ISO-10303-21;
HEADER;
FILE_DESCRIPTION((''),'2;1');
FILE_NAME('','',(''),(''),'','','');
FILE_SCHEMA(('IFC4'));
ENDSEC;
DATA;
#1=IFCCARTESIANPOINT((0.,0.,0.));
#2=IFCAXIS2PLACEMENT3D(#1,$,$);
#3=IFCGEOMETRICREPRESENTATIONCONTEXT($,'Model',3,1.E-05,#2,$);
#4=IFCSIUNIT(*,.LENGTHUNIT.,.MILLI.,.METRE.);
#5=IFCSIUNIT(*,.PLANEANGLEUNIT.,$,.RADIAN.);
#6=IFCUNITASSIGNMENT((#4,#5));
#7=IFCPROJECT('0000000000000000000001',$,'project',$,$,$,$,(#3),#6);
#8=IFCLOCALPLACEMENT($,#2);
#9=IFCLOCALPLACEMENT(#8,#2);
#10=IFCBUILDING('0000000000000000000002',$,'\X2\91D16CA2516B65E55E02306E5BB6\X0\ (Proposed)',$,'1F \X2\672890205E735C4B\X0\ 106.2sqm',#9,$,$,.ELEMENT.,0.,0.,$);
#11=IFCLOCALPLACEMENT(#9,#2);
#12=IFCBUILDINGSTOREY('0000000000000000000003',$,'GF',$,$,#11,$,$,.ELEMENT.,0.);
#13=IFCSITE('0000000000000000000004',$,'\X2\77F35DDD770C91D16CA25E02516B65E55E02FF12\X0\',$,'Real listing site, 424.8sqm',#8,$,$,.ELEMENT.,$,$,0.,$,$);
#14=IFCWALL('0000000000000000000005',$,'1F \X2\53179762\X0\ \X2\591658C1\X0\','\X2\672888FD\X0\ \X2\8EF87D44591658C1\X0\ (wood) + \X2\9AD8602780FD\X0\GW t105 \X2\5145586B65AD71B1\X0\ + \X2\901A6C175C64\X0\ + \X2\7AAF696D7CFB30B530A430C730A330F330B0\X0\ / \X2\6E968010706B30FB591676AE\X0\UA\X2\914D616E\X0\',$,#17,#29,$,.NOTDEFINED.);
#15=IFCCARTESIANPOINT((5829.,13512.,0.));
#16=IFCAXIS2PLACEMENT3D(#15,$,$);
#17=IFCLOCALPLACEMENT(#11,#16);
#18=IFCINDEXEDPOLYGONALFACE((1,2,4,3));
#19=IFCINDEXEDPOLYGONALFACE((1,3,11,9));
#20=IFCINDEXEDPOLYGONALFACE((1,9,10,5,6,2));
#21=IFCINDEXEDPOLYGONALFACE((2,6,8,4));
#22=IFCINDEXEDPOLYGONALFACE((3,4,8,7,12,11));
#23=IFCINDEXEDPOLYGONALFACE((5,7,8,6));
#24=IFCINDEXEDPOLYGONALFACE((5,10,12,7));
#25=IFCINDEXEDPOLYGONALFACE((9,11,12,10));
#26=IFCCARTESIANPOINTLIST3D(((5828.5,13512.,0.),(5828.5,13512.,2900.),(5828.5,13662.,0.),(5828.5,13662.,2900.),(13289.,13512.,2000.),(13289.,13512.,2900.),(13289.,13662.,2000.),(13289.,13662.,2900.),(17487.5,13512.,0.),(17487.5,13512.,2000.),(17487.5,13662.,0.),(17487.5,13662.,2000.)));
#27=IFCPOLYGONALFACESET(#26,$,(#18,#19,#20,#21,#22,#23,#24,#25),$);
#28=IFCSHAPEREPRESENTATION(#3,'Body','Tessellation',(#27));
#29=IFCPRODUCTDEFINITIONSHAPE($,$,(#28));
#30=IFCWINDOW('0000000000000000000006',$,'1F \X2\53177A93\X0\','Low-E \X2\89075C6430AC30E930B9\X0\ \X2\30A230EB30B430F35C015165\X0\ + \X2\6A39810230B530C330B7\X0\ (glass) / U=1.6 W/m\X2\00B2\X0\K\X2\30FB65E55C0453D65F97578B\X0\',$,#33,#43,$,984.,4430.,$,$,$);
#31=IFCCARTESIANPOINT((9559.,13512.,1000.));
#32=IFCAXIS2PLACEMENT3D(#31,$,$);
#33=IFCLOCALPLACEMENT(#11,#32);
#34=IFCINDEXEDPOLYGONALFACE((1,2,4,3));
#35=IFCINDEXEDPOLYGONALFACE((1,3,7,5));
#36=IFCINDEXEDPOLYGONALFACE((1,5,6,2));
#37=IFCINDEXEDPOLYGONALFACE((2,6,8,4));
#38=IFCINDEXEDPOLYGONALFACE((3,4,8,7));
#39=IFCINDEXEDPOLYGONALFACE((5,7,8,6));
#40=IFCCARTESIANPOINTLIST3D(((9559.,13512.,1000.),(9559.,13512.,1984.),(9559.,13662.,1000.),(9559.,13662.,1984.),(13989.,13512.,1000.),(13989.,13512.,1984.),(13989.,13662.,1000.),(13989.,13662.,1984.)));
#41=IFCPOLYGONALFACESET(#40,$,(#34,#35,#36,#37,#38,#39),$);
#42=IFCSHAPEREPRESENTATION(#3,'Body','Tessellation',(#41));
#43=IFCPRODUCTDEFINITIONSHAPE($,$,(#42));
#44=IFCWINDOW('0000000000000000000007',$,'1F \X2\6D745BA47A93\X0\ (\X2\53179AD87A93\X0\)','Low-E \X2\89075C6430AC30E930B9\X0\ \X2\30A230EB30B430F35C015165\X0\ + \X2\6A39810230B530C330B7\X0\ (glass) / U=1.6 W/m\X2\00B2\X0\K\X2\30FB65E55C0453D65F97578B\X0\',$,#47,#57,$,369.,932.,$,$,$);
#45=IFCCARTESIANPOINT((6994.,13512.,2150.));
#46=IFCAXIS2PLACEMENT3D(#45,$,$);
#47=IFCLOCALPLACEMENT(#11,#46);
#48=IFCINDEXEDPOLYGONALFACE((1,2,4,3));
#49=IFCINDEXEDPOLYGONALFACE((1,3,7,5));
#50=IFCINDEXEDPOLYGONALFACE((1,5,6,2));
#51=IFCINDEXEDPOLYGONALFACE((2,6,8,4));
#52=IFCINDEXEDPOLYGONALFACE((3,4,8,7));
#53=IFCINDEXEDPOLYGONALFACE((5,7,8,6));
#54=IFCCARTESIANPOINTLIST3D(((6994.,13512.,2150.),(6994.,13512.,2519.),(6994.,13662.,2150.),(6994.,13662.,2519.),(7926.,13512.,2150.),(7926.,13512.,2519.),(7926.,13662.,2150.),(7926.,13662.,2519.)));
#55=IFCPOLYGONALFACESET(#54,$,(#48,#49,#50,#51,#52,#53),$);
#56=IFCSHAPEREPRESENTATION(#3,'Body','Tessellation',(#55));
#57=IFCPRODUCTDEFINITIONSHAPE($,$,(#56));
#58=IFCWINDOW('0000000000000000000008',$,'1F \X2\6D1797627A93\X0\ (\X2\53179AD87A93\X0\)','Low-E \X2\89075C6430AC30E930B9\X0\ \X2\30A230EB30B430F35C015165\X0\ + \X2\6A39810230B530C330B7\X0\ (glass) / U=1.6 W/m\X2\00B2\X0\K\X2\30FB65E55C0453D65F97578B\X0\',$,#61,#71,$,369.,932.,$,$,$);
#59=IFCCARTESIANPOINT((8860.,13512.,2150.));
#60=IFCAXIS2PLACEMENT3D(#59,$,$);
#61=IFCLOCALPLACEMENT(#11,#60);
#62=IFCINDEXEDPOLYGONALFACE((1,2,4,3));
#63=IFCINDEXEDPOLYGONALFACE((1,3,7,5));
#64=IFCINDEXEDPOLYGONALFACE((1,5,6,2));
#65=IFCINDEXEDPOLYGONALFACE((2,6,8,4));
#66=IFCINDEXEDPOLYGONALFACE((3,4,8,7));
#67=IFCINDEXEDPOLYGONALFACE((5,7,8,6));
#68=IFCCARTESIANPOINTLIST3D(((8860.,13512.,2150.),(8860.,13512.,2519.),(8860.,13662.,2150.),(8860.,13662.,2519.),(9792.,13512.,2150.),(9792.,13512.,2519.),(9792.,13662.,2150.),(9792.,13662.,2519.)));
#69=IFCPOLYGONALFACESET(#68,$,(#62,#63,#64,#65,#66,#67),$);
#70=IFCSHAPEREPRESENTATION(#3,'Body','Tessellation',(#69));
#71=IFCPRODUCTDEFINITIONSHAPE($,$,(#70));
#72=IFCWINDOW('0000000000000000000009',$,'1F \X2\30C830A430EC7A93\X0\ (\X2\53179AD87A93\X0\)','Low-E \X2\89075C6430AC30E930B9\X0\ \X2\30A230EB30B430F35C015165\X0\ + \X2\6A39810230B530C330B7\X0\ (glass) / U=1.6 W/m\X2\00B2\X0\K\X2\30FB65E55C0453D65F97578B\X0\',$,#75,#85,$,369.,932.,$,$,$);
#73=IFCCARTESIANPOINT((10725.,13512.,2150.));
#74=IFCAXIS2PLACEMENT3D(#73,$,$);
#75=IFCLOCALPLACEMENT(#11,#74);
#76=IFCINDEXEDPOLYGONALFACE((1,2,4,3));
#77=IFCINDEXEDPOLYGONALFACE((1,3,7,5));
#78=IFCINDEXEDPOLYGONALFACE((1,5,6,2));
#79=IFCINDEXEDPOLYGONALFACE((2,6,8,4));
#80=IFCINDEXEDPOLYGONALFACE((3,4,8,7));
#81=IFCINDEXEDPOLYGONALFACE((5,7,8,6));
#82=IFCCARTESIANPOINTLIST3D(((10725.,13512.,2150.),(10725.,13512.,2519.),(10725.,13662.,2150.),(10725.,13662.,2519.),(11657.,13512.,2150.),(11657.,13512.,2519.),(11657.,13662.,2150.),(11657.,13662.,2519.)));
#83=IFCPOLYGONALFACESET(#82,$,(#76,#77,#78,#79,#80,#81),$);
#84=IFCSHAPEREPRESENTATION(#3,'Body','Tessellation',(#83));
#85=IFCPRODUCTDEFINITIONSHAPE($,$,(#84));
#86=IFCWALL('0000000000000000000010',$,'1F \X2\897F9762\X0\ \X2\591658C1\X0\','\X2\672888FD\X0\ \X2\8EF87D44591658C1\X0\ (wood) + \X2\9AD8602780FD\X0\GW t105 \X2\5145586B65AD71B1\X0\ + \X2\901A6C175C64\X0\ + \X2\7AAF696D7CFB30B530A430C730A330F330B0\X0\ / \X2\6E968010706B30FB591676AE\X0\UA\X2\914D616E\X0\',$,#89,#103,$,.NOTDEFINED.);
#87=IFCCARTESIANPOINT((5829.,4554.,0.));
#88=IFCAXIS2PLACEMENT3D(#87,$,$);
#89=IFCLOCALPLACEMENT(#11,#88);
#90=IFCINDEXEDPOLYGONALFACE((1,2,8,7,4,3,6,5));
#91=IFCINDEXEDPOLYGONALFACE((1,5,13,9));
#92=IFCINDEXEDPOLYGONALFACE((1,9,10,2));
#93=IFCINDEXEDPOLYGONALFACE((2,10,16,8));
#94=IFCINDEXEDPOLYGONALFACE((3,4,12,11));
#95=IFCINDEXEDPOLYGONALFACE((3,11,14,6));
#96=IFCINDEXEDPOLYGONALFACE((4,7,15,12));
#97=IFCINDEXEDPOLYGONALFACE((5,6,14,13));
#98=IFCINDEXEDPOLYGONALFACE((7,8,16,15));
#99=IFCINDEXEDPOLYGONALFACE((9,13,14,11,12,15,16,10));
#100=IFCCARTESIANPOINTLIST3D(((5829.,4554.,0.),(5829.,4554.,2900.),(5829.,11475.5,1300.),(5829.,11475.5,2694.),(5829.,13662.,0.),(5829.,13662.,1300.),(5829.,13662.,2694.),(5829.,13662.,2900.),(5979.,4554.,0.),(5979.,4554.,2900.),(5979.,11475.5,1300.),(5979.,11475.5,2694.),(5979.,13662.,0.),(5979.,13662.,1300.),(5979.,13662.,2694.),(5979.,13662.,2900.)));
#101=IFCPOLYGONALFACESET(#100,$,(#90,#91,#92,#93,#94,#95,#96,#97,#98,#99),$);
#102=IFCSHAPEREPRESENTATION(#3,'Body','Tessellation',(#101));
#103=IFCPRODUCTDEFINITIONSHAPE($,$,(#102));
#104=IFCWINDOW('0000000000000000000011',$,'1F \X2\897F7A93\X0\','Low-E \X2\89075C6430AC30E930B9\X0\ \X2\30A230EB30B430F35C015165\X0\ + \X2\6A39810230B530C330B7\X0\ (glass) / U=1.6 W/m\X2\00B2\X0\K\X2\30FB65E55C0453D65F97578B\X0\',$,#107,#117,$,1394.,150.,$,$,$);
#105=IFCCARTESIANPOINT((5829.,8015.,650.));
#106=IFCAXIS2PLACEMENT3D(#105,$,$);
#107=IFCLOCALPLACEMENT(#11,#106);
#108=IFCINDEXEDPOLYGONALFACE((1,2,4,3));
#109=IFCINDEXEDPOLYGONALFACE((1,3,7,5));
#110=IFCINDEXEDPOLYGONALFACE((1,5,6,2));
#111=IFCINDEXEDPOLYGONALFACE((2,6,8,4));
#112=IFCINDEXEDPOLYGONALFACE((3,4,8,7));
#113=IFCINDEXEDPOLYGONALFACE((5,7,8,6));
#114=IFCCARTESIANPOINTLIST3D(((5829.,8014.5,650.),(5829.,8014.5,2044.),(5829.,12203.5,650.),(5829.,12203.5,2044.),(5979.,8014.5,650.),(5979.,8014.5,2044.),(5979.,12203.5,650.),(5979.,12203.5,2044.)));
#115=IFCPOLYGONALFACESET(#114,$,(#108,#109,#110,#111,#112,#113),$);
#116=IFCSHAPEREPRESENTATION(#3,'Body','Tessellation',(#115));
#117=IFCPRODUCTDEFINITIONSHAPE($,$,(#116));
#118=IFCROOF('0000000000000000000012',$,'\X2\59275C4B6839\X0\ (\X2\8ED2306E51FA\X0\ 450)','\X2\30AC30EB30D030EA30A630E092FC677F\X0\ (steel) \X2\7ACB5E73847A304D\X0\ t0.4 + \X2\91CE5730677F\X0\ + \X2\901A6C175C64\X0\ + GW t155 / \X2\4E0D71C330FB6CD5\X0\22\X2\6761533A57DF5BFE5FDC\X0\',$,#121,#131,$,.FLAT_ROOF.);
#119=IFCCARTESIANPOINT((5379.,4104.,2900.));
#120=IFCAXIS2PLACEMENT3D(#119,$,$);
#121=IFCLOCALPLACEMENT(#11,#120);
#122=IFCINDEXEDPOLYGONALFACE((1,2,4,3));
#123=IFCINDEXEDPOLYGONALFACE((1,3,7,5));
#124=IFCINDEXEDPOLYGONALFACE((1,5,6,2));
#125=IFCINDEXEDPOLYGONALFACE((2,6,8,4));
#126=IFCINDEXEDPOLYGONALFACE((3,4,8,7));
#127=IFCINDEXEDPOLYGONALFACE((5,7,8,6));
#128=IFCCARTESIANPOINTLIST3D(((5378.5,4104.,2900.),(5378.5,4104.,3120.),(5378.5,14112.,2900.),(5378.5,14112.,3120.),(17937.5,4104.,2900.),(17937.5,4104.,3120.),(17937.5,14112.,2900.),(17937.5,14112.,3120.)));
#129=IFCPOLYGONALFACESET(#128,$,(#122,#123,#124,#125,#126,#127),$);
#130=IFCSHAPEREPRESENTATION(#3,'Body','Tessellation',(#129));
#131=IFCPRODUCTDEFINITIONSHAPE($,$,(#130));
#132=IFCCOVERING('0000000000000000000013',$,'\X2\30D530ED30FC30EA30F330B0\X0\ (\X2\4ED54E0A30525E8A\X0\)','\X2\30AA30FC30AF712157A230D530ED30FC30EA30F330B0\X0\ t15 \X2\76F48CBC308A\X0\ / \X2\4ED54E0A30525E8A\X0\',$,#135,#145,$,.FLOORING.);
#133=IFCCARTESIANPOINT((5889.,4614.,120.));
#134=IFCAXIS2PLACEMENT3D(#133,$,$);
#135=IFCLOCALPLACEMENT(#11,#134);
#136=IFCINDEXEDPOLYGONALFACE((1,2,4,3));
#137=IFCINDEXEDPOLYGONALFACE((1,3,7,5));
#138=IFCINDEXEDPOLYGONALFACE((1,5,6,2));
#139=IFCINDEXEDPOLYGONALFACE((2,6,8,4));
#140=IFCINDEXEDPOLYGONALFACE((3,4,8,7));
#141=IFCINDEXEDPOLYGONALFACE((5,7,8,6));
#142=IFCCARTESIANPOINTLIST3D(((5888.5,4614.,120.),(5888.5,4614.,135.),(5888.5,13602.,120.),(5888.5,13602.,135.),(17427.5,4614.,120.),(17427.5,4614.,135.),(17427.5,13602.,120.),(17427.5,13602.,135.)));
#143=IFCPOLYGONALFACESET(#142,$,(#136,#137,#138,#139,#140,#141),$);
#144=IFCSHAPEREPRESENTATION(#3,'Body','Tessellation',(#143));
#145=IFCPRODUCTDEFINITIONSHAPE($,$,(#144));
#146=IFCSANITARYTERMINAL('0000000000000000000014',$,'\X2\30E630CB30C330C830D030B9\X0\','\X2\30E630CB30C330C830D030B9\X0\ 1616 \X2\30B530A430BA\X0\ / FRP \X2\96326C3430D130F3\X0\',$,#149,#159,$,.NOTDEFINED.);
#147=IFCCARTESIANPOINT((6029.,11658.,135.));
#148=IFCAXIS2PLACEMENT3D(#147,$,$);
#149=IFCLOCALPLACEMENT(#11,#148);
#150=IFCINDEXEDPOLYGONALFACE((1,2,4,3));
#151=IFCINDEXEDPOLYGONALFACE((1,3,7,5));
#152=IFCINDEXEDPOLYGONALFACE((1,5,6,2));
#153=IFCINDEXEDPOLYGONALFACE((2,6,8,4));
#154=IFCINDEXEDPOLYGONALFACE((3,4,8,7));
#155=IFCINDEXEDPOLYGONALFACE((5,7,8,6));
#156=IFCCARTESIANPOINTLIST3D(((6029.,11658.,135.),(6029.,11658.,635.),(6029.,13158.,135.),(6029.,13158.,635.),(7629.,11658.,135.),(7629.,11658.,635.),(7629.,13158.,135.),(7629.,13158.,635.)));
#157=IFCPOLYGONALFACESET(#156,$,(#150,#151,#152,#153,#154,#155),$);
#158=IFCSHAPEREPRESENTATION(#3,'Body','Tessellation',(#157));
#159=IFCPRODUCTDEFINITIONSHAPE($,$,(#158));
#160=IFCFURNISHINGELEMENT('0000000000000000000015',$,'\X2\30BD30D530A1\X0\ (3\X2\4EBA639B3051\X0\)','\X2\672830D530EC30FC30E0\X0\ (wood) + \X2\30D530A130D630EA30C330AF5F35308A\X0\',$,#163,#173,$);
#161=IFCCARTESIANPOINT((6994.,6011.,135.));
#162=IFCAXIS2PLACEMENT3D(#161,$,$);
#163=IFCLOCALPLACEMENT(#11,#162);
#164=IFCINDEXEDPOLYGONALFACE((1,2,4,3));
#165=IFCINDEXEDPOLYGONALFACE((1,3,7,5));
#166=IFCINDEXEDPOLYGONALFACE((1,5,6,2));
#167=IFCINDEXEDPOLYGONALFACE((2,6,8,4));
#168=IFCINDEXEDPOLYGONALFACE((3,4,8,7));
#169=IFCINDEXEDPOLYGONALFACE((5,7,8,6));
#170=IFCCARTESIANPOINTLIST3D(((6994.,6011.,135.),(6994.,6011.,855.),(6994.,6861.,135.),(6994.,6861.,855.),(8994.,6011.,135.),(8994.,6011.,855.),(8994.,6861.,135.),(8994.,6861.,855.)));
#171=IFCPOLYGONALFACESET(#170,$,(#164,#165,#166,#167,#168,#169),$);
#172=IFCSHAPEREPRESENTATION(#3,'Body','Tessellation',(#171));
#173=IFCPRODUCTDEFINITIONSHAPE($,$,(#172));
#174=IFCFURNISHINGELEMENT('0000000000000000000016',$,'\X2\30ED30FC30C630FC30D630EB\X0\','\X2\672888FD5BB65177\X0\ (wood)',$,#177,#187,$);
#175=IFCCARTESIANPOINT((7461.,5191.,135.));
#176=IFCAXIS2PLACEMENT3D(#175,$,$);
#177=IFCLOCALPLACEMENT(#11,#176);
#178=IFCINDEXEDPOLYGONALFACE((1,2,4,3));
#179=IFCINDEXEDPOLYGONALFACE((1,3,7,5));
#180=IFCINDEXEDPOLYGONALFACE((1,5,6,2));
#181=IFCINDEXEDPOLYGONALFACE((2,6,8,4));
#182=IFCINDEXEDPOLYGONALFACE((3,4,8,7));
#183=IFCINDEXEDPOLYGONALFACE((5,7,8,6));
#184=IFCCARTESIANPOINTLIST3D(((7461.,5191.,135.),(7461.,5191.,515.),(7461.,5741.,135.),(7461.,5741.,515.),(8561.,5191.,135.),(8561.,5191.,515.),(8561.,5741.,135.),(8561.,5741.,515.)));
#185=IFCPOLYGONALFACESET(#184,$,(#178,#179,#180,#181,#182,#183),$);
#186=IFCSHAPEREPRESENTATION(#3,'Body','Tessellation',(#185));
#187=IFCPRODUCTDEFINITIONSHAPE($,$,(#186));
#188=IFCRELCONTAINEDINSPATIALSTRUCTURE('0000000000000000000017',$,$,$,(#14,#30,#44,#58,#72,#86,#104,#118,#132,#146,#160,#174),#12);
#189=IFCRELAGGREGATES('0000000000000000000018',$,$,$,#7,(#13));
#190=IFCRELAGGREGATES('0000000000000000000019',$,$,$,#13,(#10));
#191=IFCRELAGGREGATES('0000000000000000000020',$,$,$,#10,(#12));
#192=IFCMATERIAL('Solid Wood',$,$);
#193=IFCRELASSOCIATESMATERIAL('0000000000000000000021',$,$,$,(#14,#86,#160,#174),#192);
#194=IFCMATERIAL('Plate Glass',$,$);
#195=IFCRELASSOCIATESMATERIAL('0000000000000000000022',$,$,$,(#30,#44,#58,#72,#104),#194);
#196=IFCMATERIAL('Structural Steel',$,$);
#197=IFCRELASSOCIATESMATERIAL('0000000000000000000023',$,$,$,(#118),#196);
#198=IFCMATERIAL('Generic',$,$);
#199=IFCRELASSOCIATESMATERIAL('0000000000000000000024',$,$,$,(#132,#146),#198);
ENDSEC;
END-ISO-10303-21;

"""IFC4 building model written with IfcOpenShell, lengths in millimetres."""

from ifc_helpers import new_model, si_unit, frame, frame_2d, origin, place, context, project, spatial, rectangle, extrude, material, element, fill, save


model = new_model("IFC4")

# Units and contexts
model_context = context("Model", 3, precision=1e-05, world=origin())
ifc_project = project(units=[si_unit("LENGTHUNIT", "METRE", prefix="MILLI"), si_unit("PLANEANGLEUNIT", "RADIAN")], contexts=[model_context])

# Site, building, storey
site_placement = place(None, origin())
site = spatial("IfcSite", under=ifc_project, at=site_placement, Name="石川県金沢市八日市２", ObjectType="Real listing site, 424.8sqm", CompositionType="ELEMENT", RefElevation=0.0)
building_placement = place(site_placement, origin())
building = spatial("IfcBuilding", under=site, at=building_placement, Name="金沢八日市の家 (Proposed)", ObjectType="1F 木造平屋 106.2sqm", CompositionType="ELEMENT", ElevationOfRefHeight=0.0, ElevationOfTerrain=0.0)
storey_placement = place(building_placement, origin())
storey = spatial("IfcBuildingStorey", under=building, at=storey_placement, Name="GF", CompositionType="ELEMENT", Elevation=0.0)

# Shared definitions
ifc_material_1 = material(Name="Solid Wood")

# Shared definitions
ifc_material_2 = material(Name="Plate Glass")

# Wall, openings, windows
wall_1_placement = place(storey_placement, frame((5829.0, 13512.0, 0.0)))
wall_1 = element("IfcWall", 1, at=wall_1_placement, inside=storey, material=ifc_material_1, Name="1F 北面 外壁", Description="木製 軸組外壁 (wood) + 高性能GW t105 充填断熱 + 通気層 + 窯業系サイディング / 準耐火・外皮UA配慮", PredefinedType="NOTDEFINED", context=model_context, shape_type="SweptSolid", body=[
    extrude(rectangle(XDim=11659.0, YDim=150.0, at=frame_2d((5829.0, 75.0))), frame((5829.0, 13512.0, 0.0)), (0.0, 0.0, 1.0), 2900.0),
])
opening_1_placement = place(storey_placement, frame((9559.0, 13512.0, 1000.0)))
opening_1 = element("IfcOpeningElement", 2, at=opening_1_placement, cuts=wall_1, PredefinedType="NOTDEFINED", context=model_context, shape_type="SweptSolid", body=[
    extrude(rectangle(XDim=4430.0, YDim=150.0, at=frame_2d((2215.0, 75.0))), frame((9559.0, 13512.0, 1000.0)), (0.0, 0.0, 1.0), 984.0),
])
opening_2_placement = place(storey_placement, frame((6994.0, 13512.0, 2150.0)))
opening_2 = element("IfcOpeningElement", 3, at=opening_2_placement, cuts=wall_1, PredefinedType="NOTDEFINED", context=model_context, shape_type="SweptSolid", body=[
    extrude(rectangle(XDim=932.0, YDim=150.0, at=frame_2d((466.0, 75.0))), frame((6994.0, 13512.0, 2150.0)), (0.0, 0.0, 1.0), 369.0),
])
opening_3_placement = place(storey_placement, frame((8860.0, 13512.0, 2150.0)))
opening_3 = element("IfcOpeningElement", 4, at=opening_3_placement, cuts=wall_1, PredefinedType="NOTDEFINED", context=model_context, shape_type="SweptSolid", body=[
    extrude(rectangle(XDim=932.0, YDim=150.0, at=frame_2d((466.0, 75.0))), frame((8860.0, 13512.0, 2150.0)), (0.0, 0.0, 1.0), 369.0),
])
opening_4_placement = place(storey_placement, frame((10725.0, 13512.0, 2150.0)))
opening_4 = element("IfcOpeningElement", 5, at=opening_4_placement, cuts=wall_1, PredefinedType="NOTDEFINED", context=model_context, shape_type="SweptSolid", body=[
    extrude(rectangle(XDim=932.0, YDim=150.0, at=frame_2d((466.0, 75.0))), frame((10725.0, 13512.0, 2150.0)), (0.0, 0.0, 1.0), 369.0),
])
window_1_placement = place(storey_placement, frame((9559.0, 13512.0, 1000.0)))
window_1 = element("IfcWindow", 6, at=window_1_placement, inside=storey, material=ifc_material_2, Name="1F 北窓", Description="Low-E 複層ガラス アルゴン封入 + 樹脂サッシ (glass) / U=1.6 W/m²K・日射取得型", OverallHeight=984.0, OverallWidth=4430.0, context=model_context, shape_type="SweptSolid", body=[
    extrude(rectangle(XDim=4430.0, YDim=150.0, at=frame_2d((2215.0, 75.0))), frame((9559.0, 13512.0, 1000.0)), (0.0, 0.0, 1.0), 984.0),
])
fill(opening_1, window_1)
window_2_placement = place(storey_placement, frame((6994.0, 13512.0, 2150.0)))
window_2 = element("IfcWindow", 7, at=window_2_placement, inside=storey, material=ifc_material_2, Name="1F 浴室窓 (北高窓)", Description="Low-E 複層ガラス アルゴン封入 + 樹脂サッシ (glass) / U=1.6 W/m²K・日射取得型", OverallHeight=369.0, OverallWidth=932.0, context=model_context, shape_type="SweptSolid", body=[
    extrude(rectangle(XDim=932.0, YDim=150.0, at=frame_2d((466.0, 75.0))), frame((6994.0, 13512.0, 2150.0)), (0.0, 0.0, 1.0), 369.0),
])
fill(opening_2, window_2)
window_3_placement = place(storey_placement, frame((8860.0, 13512.0, 2150.0)))
window_3 = element("IfcWindow", 8, at=window_3_placement, inside=storey, material=ifc_material_2, Name="1F 洗面窓 (北高窓)", Description="Low-E 複層ガラス アルゴン封入 + 樹脂サッシ (glass) / U=1.6 W/m²K・日射取得型", OverallHeight=369.0, OverallWidth=932.0, context=model_context, shape_type="SweptSolid", body=[
    extrude(rectangle(XDim=932.0, YDim=150.0, at=frame_2d((466.0, 75.0))), frame((8860.0, 13512.0, 2150.0)), (0.0, 0.0, 1.0), 369.0),
])
fill(opening_3, window_3)
window_4_placement = place(storey_placement, frame((10725.0, 13512.0, 2150.0)))
window_4 = element("IfcWindow", 9, at=window_4_placement, inside=storey, material=ifc_material_2, Name="1F トイレ窓 (北高窓)", Description="Low-E 複層ガラス アルゴン封入 + 樹脂サッシ (glass) / U=1.6 W/m²K・日射取得型", OverallHeight=369.0, OverallWidth=932.0, context=model_context, shape_type="SweptSolid", body=[
    extrude(rectangle(XDim=932.0, YDim=150.0, at=frame_2d((466.0, 75.0))), frame((10725.0, 13512.0, 2150.0)), (0.0, 0.0, 1.0), 369.0),
])
fill(opening_4, window_4)

# Wall, opening, window
wall_2_placement = place(storey_placement, frame((5829.0, 4554.0, 0.0)))
wall_2 = element("IfcWall", 10, at=wall_2_placement, inside=storey, material=ifc_material_1, Name="1F 西面 外壁", Description="木製 軸組外壁 (wood) + 高性能GW t105 充填断熱 + 通気層 + 窯業系サイディング / 準耐火・外皮UA配慮", PredefinedType="NOTDEFINED", context=model_context, shape_type="SweptSolid", body=[
    extrude(rectangle(XDim=150.0, YDim=9108.0, at=frame_2d((75.0, 4554.0))), frame((5829.0, 4554.0, 0.0)), (0.0, 0.0, 1.0), 2900.0),
])
opening_5_placement = place(storey_placement, frame((5829.0, 8015.0, 650.0)))
opening_5 = element("IfcOpeningElement", 11, at=opening_5_placement, cuts=wall_2, PredefinedType="NOTDEFINED", context=model_context, shape_type="SweptSolid", body=[
    extrude(rectangle(XDim=150.0, YDim=4189.0, at=frame_2d((75.0, 2094.0))), frame((5829.0, 8015.0, 650.0)), (0.0, 0.0, 1.0), 1394.0),
])
window_5_placement = place(storey_placement, frame((5829.0, 8015.0, 650.0)))
window_5 = element("IfcWindow", 12, at=window_5_placement, inside=storey, material=ifc_material_2, Name="1F 西窓", Description="Low-E 複層ガラス アルゴン封入 + 樹脂サッシ (glass) / U=1.6 W/m²K・日射取得型", OverallHeight=1394.0, OverallWidth=150.0, context=model_context, shape_type="SweptSolid", body=[
    extrude(rectangle(XDim=150.0, YDim=4189.0, at=frame_2d((75.0, 2094.0))), frame((5829.0, 8015.0, 650.0)), (0.0, 0.0, 1.0), 1394.0),
])
fill(opening_5, window_5)

# Roof
ifc_material_3 = material(Name="Structural Steel")
roof_placement = place(storey_placement, frame((5379.0, 4104.0, 2900.0)))
element("IfcRoof", 13, at=roof_placement, inside=storey, material=ifc_material_3, Name="大屋根 (軒の出 450)", Description="ガルバリウム鋼板 (steel) 立平葺き t0.4 + 野地板 + 通気層 + GW t155 / 不燃・法22条区域対応", PredefinedType="FLAT_ROOF", context=model_context, shape_type="SweptSolid", body=[
    extrude(rectangle(XDim=12559.0, YDim=10008.0, at=frame_2d((6279.0, 5004.0))), frame((5379.0, 4104.0, 2900.0)), (0.0, 0.0, 1.0), 220.0),
])

# Covering
ifc_material_4 = material(Name="Generic")
covering_placement = place(storey_placement, frame((5889.0, 4614.0, 120.0)))
element("IfcCovering", 14, at=covering_placement, inside=storey, material=ifc_material_4, Name="フローリング (仕上げ床)", Description="オーク無垢フローリング t15 直貼り / 仕上げ床", PredefinedType="FLOORING", context=model_context, shape_type="SweptSolid", body=[
    extrude(rectangle(XDim=11539.0, YDim=8988.0, at=frame_2d((5769.0, 4494.0))), frame((5889.0, 4614.0, 120.0)), (0.0, 0.0, 1.0), 15.0),
])

# Sanitary terminal
sanitary_terminal_placement = place(storey_placement, frame((6029.0, 11658.0, 135.0)))
element("IfcSanitaryTerminal", 15, at=sanitary_terminal_placement, inside=storey, material=ifc_material_4, Name="ユニットバス", Description="ユニットバス 1616 サイズ / FRP 防水パン", PredefinedType="NOTDEFINED", context=model_context, shape_type="SweptSolid", body=[
    extrude(rectangle(XDim=1600.0, YDim=1500.0, at=frame_2d((800.0, 750.0))), frame((6029.0, 11658.0, 135.0)), (0.0, 0.0, 1.0), 500.0),
])

# Furnishing elements
furnishing_1_placement = place(storey_placement, frame((6994.0, 6011.0, 135.0)))
element("IfcFurnishingElement", 16, at=furnishing_1_placement, inside=storey, material=ifc_material_1, Name="ソファ (3人掛け)", Description="木フレーム (wood) + ファブリック張り", context=model_context, shape_type="SweptSolid", body=[
    extrude(rectangle(XDim=2000.0, YDim=850.0, at=frame_2d((1000.0, 425.0))), frame((6994.0, 6011.0, 135.0)), (0.0, 0.0, 1.0), 720.0),
])
furnishing_2_placement = place(storey_placement, frame((7461.0, 5191.0, 135.0)))
element("IfcFurnishingElement", 17, at=furnishing_2_placement, inside=storey, material=ifc_material_1, Name="ローテーブル", Description="木製家具 (wood)", context=model_context, shape_type="SweptSolid", body=[
    extrude(rectangle(XDim=1100.0, YDim=550.0, at=frame_2d((550.0, 275.0))), frame((7461.0, 5191.0, 135.0)), (0.0, 0.0, 1.0), 380.0),
])

save(model, "model.ifc")
